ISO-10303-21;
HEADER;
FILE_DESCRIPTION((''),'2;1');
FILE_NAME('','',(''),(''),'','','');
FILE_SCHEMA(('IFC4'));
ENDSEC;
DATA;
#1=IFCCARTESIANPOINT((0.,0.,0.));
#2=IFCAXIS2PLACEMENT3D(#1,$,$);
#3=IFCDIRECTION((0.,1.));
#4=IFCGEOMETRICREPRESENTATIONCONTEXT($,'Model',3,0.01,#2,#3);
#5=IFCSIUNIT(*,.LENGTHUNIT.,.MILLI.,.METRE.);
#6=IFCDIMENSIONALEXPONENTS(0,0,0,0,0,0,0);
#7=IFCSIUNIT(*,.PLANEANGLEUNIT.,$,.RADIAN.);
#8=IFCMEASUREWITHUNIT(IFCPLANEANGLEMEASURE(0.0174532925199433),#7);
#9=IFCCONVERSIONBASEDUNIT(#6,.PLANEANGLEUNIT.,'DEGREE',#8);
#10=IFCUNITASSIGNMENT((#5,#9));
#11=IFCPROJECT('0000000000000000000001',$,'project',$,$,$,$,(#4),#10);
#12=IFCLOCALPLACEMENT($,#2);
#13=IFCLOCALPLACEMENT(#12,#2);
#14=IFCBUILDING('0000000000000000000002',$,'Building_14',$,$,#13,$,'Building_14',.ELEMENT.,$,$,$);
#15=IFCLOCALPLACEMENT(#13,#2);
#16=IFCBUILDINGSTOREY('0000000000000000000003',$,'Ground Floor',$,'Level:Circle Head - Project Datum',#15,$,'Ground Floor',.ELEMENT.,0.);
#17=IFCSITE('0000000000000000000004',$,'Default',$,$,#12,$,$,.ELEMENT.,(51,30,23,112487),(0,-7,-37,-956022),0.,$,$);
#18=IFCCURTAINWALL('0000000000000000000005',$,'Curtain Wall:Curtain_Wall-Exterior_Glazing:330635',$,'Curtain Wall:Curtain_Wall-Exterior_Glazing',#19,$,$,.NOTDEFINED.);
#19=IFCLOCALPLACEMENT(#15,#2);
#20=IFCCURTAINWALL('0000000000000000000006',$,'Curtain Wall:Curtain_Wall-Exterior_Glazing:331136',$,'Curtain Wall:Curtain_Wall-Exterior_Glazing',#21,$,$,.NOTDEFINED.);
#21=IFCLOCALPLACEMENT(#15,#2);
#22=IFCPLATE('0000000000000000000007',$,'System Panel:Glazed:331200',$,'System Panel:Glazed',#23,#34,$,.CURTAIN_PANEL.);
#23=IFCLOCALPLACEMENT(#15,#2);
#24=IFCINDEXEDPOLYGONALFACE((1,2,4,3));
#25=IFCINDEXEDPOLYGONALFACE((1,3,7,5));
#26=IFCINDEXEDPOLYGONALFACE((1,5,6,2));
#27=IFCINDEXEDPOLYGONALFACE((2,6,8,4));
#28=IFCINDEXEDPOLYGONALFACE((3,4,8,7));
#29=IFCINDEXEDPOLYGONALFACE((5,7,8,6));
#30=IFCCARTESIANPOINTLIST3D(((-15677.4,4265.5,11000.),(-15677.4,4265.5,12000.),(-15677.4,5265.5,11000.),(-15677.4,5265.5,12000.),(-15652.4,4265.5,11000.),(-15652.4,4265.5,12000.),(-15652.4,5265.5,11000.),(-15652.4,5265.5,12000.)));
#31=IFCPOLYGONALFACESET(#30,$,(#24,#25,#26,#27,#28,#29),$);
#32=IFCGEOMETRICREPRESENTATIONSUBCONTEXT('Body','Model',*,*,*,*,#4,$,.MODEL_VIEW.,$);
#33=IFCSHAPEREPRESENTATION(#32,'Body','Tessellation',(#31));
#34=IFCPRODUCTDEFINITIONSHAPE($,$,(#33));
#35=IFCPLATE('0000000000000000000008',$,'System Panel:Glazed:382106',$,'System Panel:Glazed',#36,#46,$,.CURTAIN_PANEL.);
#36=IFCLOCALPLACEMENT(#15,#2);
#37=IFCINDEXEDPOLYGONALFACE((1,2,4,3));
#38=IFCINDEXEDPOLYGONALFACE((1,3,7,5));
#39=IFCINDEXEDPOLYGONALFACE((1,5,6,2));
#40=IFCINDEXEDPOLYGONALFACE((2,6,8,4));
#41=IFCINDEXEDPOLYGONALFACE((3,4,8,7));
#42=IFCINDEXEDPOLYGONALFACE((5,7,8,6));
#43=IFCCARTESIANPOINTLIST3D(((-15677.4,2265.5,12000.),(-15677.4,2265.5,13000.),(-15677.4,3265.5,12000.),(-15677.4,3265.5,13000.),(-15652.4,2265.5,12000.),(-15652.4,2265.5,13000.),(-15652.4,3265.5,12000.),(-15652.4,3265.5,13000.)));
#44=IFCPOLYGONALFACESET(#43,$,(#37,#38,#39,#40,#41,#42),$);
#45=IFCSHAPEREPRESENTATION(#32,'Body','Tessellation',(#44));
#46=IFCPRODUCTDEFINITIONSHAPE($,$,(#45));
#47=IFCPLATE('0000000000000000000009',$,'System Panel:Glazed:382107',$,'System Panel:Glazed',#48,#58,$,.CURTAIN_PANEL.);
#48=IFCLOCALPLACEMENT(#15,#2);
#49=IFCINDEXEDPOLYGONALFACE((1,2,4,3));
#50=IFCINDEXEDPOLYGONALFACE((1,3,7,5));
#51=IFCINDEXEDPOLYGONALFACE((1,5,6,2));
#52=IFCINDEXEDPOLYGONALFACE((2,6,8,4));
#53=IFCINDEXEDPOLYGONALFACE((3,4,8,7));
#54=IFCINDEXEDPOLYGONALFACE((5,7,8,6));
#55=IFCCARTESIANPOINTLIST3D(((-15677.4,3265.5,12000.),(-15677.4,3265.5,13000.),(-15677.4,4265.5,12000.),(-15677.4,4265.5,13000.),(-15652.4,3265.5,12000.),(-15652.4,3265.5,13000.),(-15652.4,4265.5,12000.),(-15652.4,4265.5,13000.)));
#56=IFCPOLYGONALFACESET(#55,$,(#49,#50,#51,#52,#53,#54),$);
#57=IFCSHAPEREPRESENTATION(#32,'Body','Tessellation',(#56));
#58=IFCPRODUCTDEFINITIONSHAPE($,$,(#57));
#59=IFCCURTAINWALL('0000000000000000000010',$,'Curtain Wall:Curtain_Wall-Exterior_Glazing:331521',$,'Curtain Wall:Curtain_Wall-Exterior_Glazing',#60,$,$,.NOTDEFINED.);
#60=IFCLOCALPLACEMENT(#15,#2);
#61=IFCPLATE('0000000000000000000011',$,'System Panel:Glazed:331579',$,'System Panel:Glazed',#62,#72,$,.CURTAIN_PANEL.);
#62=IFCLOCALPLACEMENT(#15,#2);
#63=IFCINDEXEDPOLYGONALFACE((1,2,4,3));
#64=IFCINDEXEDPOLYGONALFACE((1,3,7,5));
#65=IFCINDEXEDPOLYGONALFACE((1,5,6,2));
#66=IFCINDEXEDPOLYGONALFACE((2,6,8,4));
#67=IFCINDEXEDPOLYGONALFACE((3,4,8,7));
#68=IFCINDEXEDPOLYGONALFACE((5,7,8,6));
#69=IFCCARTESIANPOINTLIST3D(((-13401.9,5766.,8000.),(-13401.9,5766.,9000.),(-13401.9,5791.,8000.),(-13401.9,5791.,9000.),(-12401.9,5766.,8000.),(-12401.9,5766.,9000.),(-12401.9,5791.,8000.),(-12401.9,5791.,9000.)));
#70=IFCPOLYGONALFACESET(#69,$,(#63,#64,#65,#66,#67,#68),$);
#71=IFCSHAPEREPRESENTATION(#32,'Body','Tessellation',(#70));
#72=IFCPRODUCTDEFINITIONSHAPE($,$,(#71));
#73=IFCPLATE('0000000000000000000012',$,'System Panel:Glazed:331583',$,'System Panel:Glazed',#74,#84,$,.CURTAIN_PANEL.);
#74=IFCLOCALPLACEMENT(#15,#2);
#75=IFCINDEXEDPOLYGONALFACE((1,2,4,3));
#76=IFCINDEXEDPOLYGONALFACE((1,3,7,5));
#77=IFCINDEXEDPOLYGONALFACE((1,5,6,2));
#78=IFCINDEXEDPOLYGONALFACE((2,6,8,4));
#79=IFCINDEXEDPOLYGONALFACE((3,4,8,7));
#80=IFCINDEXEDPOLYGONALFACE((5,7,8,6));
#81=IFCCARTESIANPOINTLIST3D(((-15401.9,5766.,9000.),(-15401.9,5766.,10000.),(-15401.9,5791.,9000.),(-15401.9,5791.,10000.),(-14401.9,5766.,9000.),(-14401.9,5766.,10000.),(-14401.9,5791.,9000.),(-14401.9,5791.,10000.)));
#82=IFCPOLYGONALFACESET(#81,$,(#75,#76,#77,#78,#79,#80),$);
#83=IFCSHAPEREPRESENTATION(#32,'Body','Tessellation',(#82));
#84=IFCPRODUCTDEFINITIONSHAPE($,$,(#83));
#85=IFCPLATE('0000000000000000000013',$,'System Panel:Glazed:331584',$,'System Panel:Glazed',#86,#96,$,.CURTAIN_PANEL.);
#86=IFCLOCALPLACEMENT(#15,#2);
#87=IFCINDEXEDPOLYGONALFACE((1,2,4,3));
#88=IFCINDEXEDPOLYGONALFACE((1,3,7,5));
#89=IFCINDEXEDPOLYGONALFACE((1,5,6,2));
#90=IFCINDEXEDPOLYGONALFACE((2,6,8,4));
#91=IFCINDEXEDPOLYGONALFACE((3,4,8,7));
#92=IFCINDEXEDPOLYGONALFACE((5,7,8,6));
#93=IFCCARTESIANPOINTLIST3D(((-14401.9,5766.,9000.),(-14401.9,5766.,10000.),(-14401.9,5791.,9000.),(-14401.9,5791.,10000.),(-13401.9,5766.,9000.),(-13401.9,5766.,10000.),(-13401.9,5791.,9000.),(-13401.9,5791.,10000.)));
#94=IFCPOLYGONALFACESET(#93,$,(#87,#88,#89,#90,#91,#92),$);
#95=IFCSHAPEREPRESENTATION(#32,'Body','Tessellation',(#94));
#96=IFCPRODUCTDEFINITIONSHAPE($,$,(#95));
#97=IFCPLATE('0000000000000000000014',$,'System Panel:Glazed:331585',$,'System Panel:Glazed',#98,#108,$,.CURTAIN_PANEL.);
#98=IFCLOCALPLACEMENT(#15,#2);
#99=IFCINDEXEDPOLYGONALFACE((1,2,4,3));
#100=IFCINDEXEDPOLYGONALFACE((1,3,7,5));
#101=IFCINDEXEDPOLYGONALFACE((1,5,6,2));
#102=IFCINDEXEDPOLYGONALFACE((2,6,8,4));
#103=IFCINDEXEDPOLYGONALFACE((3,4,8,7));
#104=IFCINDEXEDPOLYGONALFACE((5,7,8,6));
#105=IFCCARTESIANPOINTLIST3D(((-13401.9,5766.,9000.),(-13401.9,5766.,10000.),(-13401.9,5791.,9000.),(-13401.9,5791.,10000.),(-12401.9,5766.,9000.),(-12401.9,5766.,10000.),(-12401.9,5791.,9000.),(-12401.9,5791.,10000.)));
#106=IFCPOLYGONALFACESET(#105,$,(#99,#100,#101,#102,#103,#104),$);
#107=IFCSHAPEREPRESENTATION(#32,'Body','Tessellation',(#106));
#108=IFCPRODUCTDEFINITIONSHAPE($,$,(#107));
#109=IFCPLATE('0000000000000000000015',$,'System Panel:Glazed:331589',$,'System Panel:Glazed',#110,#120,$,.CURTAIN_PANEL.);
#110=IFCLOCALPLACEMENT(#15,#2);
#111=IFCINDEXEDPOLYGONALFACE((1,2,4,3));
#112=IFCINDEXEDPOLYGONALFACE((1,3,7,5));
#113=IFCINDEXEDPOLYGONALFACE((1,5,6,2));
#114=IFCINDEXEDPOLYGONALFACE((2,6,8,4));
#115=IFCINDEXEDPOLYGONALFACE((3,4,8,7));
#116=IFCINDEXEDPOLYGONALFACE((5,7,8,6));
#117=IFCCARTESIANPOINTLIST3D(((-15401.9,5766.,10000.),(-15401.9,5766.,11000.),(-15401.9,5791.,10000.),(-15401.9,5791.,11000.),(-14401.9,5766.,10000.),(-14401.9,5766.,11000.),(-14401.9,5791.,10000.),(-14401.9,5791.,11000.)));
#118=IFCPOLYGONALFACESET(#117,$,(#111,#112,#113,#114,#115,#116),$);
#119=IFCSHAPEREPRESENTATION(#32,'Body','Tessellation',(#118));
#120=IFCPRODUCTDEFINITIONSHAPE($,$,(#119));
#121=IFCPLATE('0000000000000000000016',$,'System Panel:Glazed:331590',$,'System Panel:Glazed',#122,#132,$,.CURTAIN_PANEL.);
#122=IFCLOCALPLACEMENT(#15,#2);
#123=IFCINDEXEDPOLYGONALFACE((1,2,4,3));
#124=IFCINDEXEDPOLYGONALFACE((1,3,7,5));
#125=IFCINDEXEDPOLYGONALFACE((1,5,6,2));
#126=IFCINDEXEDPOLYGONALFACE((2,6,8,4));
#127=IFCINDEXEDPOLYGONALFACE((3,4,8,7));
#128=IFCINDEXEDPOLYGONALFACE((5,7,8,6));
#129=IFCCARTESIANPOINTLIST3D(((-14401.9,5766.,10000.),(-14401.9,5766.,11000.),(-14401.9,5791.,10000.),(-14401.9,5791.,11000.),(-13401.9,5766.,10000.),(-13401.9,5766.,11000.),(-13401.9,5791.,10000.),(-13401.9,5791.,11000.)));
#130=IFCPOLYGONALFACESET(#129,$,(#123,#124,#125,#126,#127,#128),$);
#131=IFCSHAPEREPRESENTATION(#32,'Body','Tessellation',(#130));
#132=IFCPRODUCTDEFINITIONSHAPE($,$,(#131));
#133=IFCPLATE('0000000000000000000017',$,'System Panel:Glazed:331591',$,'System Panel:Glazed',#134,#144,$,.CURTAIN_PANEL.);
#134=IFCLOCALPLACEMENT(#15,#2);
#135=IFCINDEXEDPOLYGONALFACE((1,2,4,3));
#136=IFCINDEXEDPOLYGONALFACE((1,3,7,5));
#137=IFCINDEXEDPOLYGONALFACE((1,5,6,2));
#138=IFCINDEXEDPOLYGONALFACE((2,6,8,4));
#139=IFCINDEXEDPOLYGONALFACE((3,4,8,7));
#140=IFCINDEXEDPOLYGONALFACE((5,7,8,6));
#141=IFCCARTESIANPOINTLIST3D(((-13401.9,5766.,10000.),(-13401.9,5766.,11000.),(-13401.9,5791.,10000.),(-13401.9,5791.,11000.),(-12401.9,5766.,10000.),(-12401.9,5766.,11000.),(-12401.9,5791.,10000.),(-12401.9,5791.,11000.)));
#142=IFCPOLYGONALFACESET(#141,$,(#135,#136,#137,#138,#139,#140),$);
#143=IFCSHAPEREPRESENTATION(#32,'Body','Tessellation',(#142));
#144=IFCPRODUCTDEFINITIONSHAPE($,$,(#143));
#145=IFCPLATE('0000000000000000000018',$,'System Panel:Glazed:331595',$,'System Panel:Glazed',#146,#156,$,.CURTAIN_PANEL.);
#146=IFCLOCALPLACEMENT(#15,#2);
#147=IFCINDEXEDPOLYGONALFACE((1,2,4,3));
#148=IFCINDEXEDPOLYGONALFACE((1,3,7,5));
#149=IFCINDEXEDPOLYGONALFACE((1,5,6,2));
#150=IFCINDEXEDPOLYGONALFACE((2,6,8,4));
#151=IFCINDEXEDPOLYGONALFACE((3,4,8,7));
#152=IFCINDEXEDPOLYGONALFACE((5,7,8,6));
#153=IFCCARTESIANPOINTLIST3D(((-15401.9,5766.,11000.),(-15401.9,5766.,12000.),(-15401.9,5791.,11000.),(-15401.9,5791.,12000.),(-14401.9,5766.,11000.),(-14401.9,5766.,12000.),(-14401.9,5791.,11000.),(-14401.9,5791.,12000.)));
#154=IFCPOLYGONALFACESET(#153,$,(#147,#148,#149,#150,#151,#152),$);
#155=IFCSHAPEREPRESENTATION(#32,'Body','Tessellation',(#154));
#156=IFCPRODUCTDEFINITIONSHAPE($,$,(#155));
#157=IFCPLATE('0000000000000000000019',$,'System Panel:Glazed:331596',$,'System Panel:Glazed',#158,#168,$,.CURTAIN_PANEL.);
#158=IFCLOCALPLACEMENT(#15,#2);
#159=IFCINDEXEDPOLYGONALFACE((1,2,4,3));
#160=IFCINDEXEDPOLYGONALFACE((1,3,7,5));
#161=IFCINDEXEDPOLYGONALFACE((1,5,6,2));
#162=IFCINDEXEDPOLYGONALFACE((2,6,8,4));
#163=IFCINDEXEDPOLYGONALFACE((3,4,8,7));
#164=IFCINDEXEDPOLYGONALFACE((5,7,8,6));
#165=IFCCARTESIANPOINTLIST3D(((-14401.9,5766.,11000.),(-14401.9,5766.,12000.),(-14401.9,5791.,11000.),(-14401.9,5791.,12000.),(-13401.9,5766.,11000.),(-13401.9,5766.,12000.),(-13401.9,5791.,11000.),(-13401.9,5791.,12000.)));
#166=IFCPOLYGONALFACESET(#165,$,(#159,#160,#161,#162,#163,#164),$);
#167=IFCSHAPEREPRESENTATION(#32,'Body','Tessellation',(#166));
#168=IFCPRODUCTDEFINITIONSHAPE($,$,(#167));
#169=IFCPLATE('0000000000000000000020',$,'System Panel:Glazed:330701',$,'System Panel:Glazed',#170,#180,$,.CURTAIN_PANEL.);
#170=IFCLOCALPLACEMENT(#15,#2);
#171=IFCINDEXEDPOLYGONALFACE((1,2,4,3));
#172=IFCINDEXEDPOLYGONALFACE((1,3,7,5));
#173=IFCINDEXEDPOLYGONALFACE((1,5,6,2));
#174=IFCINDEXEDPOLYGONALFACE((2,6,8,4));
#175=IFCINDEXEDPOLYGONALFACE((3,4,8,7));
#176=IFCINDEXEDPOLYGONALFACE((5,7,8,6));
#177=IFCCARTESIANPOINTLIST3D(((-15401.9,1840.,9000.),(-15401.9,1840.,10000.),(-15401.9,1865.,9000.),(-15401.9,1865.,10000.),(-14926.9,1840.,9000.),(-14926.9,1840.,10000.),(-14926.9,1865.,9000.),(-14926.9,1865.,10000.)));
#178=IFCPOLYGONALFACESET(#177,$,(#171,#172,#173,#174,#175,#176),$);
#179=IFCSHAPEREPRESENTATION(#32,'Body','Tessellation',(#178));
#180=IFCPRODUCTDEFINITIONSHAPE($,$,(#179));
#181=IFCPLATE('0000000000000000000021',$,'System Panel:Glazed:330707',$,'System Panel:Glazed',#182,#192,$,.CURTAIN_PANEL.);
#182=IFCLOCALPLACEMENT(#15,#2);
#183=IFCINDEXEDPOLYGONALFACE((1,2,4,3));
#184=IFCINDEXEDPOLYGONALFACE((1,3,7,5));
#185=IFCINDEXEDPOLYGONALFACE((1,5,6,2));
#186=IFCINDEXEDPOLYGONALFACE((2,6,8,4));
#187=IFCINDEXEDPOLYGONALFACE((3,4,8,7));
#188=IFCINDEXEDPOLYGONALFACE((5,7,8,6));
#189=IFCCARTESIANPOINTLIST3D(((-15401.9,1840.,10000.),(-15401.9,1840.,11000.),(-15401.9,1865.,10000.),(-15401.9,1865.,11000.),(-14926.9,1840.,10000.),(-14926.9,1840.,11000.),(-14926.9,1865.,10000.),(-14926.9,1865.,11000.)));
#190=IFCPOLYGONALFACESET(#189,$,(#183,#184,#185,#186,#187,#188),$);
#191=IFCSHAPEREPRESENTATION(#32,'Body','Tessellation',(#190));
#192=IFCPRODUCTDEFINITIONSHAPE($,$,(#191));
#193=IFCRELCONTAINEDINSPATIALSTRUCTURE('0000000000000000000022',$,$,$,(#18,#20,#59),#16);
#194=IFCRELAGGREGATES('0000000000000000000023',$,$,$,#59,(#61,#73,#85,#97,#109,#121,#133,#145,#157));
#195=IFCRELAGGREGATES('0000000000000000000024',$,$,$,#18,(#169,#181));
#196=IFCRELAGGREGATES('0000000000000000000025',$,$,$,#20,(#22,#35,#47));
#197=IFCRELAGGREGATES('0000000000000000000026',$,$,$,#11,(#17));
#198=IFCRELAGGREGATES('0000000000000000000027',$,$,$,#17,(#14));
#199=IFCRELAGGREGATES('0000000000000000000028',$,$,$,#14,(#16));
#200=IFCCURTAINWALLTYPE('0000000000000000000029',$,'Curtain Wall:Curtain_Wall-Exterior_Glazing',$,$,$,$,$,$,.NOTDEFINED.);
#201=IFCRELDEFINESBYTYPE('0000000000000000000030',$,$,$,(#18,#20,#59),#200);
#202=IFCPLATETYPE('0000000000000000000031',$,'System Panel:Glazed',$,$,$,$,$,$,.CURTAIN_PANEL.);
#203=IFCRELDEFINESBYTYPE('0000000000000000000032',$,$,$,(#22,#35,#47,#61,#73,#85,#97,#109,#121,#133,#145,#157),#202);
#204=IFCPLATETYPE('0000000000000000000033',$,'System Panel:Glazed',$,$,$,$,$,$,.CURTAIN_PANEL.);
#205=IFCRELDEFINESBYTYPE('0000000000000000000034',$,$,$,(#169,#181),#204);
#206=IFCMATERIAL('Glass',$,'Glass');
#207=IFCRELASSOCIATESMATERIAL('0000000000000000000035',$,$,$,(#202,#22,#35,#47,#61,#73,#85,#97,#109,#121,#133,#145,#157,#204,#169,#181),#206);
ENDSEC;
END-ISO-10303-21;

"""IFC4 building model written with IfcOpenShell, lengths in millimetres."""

from ifc_helpers import new_model, entity, si_unit, converted_unit, direction, frame, origin, place, context, subcontext, project, spatial, indexed_curve, outline, extrude, source, transform, mapped, material, type_object, type_shapes, element, aggregate, save


model = new_model("IFC4")

# Units and contexts
model_context = context("Model", 3, precision=0.01, world=origin(), true_north=direction((0.0, 1.0)))
body_context = subcontext(model_context, "Body", "Model", "MODEL_VIEW")
ifc_project = project(units=[si_unit("LENGTHUNIT", "METRE", prefix="MILLI"), converted_unit("PLANEANGLEUNIT", "DEGREE", entity("IfcPlaneAngleMeasure", 0.0174532925199433), si_unit("PLANEANGLEUNIT", "RADIAN"), dimensions=[0, 0, 0, 0, 0, 0, 0])], contexts=[model_context])

# Site, building, storey
site_placement = place(None, origin())
site = spatial("IfcSite", under=ifc_project, at=site_placement, Name="Default", CompositionType="ELEMENT", RefLatitude=(51, 30, 23, 112487), RefLongitude=(0, -7, -37, -956022), RefElevation=0.0)
building_placement = place(site_placement, origin())
building = spatial("IfcBuilding", under=site, at=building_placement, Name="Building_14", LongName="Building_14", CompositionType="ELEMENT")
storey_placement = place(building_placement, origin())
storey = spatial("IfcBuildingStorey", under=building, at=storey_placement, Name="Ground Floor", ObjectType="Level:Circle Head - Project Datum", LongName="Ground Floor", CompositionType="ELEMENT", Elevation=0.0)

# Curtain walls, plates
curtain_wall_type = type_object("IfcCurtainWallType", Name="Curtain Wall:Curtain_Wall-Exterior_Glazing", PredefinedType="NOTDEFINED")
curtain_wall_1_placement = place(storey_placement, origin())
curtain_wall_1 = element("IfcCurtainWall", 1, at=curtain_wall_1_placement, inside=storey, type_object=curtain_wall_type, Name="Curtain Wall:Curtain_Wall-Exterior_Glazing:330635", ObjectType="Curtain Wall:Curtain_Wall-Exterior_Glazing", PredefinedType="NOTDEFINED")
ifc_material = material(Name="Glass", Category="Glass")
plate_type_1 = type_object("IfcPlateType", Name="System Panel:Glazed", PredefinedType="CURTAIN_PANEL", material=ifc_material)
shared_shape_1 = source(origin(), body_context, "Body", "SweptSolid", [
    extrude(outline(indexed_curve([(-12.5, -500.0), (12.5, -500.0), (12.5, 500.0), (-12.5, 500.0), (-12.5, -500.0)], self_intersect=False)), frame((0.0, -37.0, 0.0), z_axis=(0.0, 0.0, 1.0), x_axis=(0.0, 1.0, 0.0)), (0.0, 0.0, 1.0), 1000.0),
])
type_shapes(plate_type_1, [shared_shape_1])
curtain_wall_2_placement = place(storey_placement, origin())
curtain_wall_2 = element("IfcCurtainWall", 2, at=curtain_wall_2_placement, inside=storey, type_object=curtain_wall_type, Name="Curtain Wall:Curtain_Wall-Exterior_Glazing:331136", ObjectType="Curtain Wall:Curtain_Wall-Exterior_Glazing", PredefinedType="NOTDEFINED")
plate_1_placement = place(curtain_wall_2_placement, frame((-15701.9, 4765.5, 11000.0), z_axis=(0.0, 0.0, 1.0), x_axis=(0.0, 1.0, 0.0)))
plate_1 = element("IfcPlate", 3, at=plate_1_placement, type_object=plate_type_1, material=ifc_material, Name="System Panel:Glazed:331200", ObjectType="System Panel:Glazed", PredefinedType="CURTAIN_PANEL", context=body_context, shape_type="MappedRepresentation", body=[
    mapped(shared_shape_1, transform((0.0, 0.0, 0.0), scale=1.0)),
])
plate_2_placement = place(curtain_wall_2_placement, frame((-15701.9, 2765.5, 12000.0), z_axis=(0.0, 0.0, 1.0), x_axis=(0.0, 1.0, 0.0)))
plate_2 = element("IfcPlate", 4, at=plate_2_placement, type_object=plate_type_1, material=ifc_material, Name="System Panel:Glazed:382106", ObjectType="System Panel:Glazed", PredefinedType="CURTAIN_PANEL", context=body_context, shape_type="MappedRepresentation", body=[
    mapped(shared_shape_1, transform((0.0, 0.0, 0.0), scale=1.0)),
])
plate_3_placement = place(curtain_wall_2_placement, frame((-15701.9, 3765.5, 12000.0), z_axis=(0.0, 0.0, 1.0), x_axis=(0.0, 1.0, 0.0)))
plate_3 = element("IfcPlate", 5, at=plate_3_placement, type_object=plate_type_1, material=ifc_material, Name="System Panel:Glazed:382107", ObjectType="System Panel:Glazed", PredefinedType="CURTAIN_PANEL", context=body_context, shape_type="MappedRepresentation", body=[
    mapped(shared_shape_1, transform((0.0, 0.0, 0.0), scale=1.0)),
])
curtain_wall_3_placement = place(storey_placement, origin())
curtain_wall_3 = element("IfcCurtainWall", 6, at=curtain_wall_3_placement, inside=storey, type_object=curtain_wall_type, Name="Curtain Wall:Curtain_Wall-Exterior_Glazing:331521", ObjectType="Curtain Wall:Curtain_Wall-Exterior_Glazing", PredefinedType="NOTDEFINED")
plate_4_placement = place(curtain_wall_3_placement, frame((-12901.9, 5815.5, 8000.0)))
plate_4 = element("IfcPlate", 7, at=plate_4_placement, type_object=plate_type_1, material=ifc_material, Name="System Panel:Glazed:331579", ObjectType="System Panel:Glazed", PredefinedType="CURTAIN_PANEL", context=body_context, shape_type="MappedRepresentation", body=[
    mapped(shared_shape_1, transform((0.0, 0.0, 0.0), scale=1.0)),
])
plate_5_placement = place(curtain_wall_3_placement, frame((-14901.9, 5815.5, 9000.0)))
plate_5 = element("IfcPlate", 8, at=plate_5_placement, type_object=plate_type_1, material=ifc_material, Name="System Panel:Glazed:331583", ObjectType="System Panel:Glazed", PredefinedType="CURTAIN_PANEL", context=body_context, shape_type="MappedRepresentation", body=[
    mapped(shared_shape_1, transform((0.0, 0.0, 0.0), scale=1.0)),
])
plate_6_placement = place(curtain_wall_3_placement, frame((-13901.9, 5815.5, 9000.0)))
plate_6 = element("IfcPlate", 9, at=plate_6_placement, type_object=plate_type_1, material=ifc_material, Name="System Panel:Glazed:331584", ObjectType="System Panel:Glazed", PredefinedType="CURTAIN_PANEL", context=body_context, shape_type="MappedRepresentation", body=[
    mapped(shared_shape_1, transform((0.0, 0.0, 0.0), scale=1.0)),
])
plate_7_placement = place(curtain_wall_3_placement, frame((-12901.9, 5815.5, 9000.0)))
plate_7 = element("IfcPlate", 10, at=plate_7_placement, type_object=plate_type_1, material=ifc_material, Name="System Panel:Glazed:331585", ObjectType="System Panel:Glazed", PredefinedType="CURTAIN_PANEL", context=body_context, shape_type="MappedRepresentation", body=[
    mapped(shared_shape_1, transform((0.0, 0.0, 0.0), scale=1.0)),
])
plate_8_placement = place(curtain_wall_3_placement, frame((-14901.9, 5815.5, 10000.0)))
plate_8 = element("IfcPlate", 11, at=plate_8_placement, type_object=plate_type_1, material=ifc_material, Name="System Panel:Glazed:331589", ObjectType="System Panel:Glazed", PredefinedType="CURTAIN_PANEL", context=body_context, shape_type="MappedRepresentation", body=[
    mapped(shared_shape_1, transform((0.0, 0.0, 0.0), scale=1.0)),
])
plate_9_placement = place(curtain_wall_3_placement, frame((-13901.9, 5815.5, 10000.0)))
plate_9 = element("IfcPlate", 12, at=plate_9_placement, type_object=plate_type_1, material=ifc_material, Name="System Panel:Glazed:331590", ObjectType="System Panel:Glazed", PredefinedType="CURTAIN_PANEL", context=body_context, shape_type="MappedRepresentation", body=[
    mapped(shared_shape_1, transform((0.0, 0.0, 0.0), scale=1.0)),
])
plate_10_placement = place(curtain_wall_3_placement, frame((-12901.9, 5815.5, 10000.0)))
plate_10 = element("IfcPlate", 13, at=plate_10_placement, type_object=plate_type_1, material=ifc_material, Name="System Panel:Glazed:331591", ObjectType="System Panel:Glazed", PredefinedType="CURTAIN_PANEL", context=body_context, shape_type="MappedRepresentation", body=[
    mapped(shared_shape_1, transform((0.0, 0.0, 0.0), scale=1.0)),
])
plate_11_placement = place(curtain_wall_3_placement, frame((-14901.9, 5815.5, 11000.0)))
plate_11 = element("IfcPlate", 14, at=plate_11_placement, type_object=plate_type_1, material=ifc_material, Name="System Panel:Glazed:331595", ObjectType="System Panel:Glazed", PredefinedType="CURTAIN_PANEL", context=body_context, shape_type="MappedRepresentation", body=[
    mapped(shared_shape_1, transform((0.0, 0.0, 0.0), scale=1.0)),
])
plate_12_placement = place(curtain_wall_3_placement, frame((-13901.9, 5815.5, 11000.0)))
plate_12 = element("IfcPlate", 15, at=plate_12_placement, type_object=plate_type_1, material=ifc_material, Name="System Panel:Glazed:331596", ObjectType="System Panel:Glazed", PredefinedType="CURTAIN_PANEL", context=body_context, shape_type="MappedRepresentation", body=[
    mapped(shared_shape_1, transform((0.0, 0.0, 0.0), scale=1.0)),
])
aggregate(curtain_wall_3, [plate_4, plate_5, plate_6, plate_7, plate_8, plate_9, plate_10, plate_11, plate_12])

# Plates
plate_type_2 = type_object("IfcPlateType", Name="System Panel:Glazed", PredefinedType="CURTAIN_PANEL", material=ifc_material)
shared_shape_2 = source(origin(), body_context, "Body", "SweptSolid", [
    extrude(outline(indexed_curve([(-12.5, -237.5), (12.5, -237.5), (12.5, 237.5), (-12.5, 237.5), (-12.5, -237.5)], self_intersect=False)), frame((0.0, -37.0, 0.0), z_axis=(0.0, 0.0, 1.0), x_axis=(0.0, 1.0, 0.0)), (0.0, 0.0, 1.0), 1000.0),
])
type_shapes(plate_type_2, [shared_shape_2])
plate_13_placement = place(curtain_wall_1_placement, frame((-15164.4, 1815.5, 9000.0), z_axis=(0.0, 0.0, 1.0), x_axis=(-1.0, 0.0, 0.0)))
plate_13 = element("IfcPlate", 16, at=plate_13_placement, type_object=plate_type_2, material=ifc_material, Name="System Panel:Glazed:330701", ObjectType="System Panel:Glazed", PredefinedType="CURTAIN_PANEL", context=body_context, shape_type="MappedRepresentation", body=[
    mapped(shared_shape_2, transform((0.0, 0.0, 0.0), scale=1.0)),
])
plate_14_placement = place(curtain_wall_1_placement, frame((-15164.4, 1815.5, 10000.0), z_axis=(0.0, 0.0, 1.0), x_axis=(-1.0, 0.0, 0.0)))
plate_14 = element("IfcPlate", 17, at=plate_14_placement, type_object=plate_type_2, material=ifc_material, Name="System Panel:Glazed:330707", ObjectType="System Panel:Glazed", PredefinedType="CURTAIN_PANEL", context=body_context, shape_type="MappedRepresentation", body=[
    mapped(shared_shape_2, transform((0.0, 0.0, 0.0), scale=1.0)),
])
aggregate(curtain_wall_1, [plate_13, plate_14])
aggregate(curtain_wall_2, [plate_1, plate_2, plate_3])

save(model, "model.ifc")
